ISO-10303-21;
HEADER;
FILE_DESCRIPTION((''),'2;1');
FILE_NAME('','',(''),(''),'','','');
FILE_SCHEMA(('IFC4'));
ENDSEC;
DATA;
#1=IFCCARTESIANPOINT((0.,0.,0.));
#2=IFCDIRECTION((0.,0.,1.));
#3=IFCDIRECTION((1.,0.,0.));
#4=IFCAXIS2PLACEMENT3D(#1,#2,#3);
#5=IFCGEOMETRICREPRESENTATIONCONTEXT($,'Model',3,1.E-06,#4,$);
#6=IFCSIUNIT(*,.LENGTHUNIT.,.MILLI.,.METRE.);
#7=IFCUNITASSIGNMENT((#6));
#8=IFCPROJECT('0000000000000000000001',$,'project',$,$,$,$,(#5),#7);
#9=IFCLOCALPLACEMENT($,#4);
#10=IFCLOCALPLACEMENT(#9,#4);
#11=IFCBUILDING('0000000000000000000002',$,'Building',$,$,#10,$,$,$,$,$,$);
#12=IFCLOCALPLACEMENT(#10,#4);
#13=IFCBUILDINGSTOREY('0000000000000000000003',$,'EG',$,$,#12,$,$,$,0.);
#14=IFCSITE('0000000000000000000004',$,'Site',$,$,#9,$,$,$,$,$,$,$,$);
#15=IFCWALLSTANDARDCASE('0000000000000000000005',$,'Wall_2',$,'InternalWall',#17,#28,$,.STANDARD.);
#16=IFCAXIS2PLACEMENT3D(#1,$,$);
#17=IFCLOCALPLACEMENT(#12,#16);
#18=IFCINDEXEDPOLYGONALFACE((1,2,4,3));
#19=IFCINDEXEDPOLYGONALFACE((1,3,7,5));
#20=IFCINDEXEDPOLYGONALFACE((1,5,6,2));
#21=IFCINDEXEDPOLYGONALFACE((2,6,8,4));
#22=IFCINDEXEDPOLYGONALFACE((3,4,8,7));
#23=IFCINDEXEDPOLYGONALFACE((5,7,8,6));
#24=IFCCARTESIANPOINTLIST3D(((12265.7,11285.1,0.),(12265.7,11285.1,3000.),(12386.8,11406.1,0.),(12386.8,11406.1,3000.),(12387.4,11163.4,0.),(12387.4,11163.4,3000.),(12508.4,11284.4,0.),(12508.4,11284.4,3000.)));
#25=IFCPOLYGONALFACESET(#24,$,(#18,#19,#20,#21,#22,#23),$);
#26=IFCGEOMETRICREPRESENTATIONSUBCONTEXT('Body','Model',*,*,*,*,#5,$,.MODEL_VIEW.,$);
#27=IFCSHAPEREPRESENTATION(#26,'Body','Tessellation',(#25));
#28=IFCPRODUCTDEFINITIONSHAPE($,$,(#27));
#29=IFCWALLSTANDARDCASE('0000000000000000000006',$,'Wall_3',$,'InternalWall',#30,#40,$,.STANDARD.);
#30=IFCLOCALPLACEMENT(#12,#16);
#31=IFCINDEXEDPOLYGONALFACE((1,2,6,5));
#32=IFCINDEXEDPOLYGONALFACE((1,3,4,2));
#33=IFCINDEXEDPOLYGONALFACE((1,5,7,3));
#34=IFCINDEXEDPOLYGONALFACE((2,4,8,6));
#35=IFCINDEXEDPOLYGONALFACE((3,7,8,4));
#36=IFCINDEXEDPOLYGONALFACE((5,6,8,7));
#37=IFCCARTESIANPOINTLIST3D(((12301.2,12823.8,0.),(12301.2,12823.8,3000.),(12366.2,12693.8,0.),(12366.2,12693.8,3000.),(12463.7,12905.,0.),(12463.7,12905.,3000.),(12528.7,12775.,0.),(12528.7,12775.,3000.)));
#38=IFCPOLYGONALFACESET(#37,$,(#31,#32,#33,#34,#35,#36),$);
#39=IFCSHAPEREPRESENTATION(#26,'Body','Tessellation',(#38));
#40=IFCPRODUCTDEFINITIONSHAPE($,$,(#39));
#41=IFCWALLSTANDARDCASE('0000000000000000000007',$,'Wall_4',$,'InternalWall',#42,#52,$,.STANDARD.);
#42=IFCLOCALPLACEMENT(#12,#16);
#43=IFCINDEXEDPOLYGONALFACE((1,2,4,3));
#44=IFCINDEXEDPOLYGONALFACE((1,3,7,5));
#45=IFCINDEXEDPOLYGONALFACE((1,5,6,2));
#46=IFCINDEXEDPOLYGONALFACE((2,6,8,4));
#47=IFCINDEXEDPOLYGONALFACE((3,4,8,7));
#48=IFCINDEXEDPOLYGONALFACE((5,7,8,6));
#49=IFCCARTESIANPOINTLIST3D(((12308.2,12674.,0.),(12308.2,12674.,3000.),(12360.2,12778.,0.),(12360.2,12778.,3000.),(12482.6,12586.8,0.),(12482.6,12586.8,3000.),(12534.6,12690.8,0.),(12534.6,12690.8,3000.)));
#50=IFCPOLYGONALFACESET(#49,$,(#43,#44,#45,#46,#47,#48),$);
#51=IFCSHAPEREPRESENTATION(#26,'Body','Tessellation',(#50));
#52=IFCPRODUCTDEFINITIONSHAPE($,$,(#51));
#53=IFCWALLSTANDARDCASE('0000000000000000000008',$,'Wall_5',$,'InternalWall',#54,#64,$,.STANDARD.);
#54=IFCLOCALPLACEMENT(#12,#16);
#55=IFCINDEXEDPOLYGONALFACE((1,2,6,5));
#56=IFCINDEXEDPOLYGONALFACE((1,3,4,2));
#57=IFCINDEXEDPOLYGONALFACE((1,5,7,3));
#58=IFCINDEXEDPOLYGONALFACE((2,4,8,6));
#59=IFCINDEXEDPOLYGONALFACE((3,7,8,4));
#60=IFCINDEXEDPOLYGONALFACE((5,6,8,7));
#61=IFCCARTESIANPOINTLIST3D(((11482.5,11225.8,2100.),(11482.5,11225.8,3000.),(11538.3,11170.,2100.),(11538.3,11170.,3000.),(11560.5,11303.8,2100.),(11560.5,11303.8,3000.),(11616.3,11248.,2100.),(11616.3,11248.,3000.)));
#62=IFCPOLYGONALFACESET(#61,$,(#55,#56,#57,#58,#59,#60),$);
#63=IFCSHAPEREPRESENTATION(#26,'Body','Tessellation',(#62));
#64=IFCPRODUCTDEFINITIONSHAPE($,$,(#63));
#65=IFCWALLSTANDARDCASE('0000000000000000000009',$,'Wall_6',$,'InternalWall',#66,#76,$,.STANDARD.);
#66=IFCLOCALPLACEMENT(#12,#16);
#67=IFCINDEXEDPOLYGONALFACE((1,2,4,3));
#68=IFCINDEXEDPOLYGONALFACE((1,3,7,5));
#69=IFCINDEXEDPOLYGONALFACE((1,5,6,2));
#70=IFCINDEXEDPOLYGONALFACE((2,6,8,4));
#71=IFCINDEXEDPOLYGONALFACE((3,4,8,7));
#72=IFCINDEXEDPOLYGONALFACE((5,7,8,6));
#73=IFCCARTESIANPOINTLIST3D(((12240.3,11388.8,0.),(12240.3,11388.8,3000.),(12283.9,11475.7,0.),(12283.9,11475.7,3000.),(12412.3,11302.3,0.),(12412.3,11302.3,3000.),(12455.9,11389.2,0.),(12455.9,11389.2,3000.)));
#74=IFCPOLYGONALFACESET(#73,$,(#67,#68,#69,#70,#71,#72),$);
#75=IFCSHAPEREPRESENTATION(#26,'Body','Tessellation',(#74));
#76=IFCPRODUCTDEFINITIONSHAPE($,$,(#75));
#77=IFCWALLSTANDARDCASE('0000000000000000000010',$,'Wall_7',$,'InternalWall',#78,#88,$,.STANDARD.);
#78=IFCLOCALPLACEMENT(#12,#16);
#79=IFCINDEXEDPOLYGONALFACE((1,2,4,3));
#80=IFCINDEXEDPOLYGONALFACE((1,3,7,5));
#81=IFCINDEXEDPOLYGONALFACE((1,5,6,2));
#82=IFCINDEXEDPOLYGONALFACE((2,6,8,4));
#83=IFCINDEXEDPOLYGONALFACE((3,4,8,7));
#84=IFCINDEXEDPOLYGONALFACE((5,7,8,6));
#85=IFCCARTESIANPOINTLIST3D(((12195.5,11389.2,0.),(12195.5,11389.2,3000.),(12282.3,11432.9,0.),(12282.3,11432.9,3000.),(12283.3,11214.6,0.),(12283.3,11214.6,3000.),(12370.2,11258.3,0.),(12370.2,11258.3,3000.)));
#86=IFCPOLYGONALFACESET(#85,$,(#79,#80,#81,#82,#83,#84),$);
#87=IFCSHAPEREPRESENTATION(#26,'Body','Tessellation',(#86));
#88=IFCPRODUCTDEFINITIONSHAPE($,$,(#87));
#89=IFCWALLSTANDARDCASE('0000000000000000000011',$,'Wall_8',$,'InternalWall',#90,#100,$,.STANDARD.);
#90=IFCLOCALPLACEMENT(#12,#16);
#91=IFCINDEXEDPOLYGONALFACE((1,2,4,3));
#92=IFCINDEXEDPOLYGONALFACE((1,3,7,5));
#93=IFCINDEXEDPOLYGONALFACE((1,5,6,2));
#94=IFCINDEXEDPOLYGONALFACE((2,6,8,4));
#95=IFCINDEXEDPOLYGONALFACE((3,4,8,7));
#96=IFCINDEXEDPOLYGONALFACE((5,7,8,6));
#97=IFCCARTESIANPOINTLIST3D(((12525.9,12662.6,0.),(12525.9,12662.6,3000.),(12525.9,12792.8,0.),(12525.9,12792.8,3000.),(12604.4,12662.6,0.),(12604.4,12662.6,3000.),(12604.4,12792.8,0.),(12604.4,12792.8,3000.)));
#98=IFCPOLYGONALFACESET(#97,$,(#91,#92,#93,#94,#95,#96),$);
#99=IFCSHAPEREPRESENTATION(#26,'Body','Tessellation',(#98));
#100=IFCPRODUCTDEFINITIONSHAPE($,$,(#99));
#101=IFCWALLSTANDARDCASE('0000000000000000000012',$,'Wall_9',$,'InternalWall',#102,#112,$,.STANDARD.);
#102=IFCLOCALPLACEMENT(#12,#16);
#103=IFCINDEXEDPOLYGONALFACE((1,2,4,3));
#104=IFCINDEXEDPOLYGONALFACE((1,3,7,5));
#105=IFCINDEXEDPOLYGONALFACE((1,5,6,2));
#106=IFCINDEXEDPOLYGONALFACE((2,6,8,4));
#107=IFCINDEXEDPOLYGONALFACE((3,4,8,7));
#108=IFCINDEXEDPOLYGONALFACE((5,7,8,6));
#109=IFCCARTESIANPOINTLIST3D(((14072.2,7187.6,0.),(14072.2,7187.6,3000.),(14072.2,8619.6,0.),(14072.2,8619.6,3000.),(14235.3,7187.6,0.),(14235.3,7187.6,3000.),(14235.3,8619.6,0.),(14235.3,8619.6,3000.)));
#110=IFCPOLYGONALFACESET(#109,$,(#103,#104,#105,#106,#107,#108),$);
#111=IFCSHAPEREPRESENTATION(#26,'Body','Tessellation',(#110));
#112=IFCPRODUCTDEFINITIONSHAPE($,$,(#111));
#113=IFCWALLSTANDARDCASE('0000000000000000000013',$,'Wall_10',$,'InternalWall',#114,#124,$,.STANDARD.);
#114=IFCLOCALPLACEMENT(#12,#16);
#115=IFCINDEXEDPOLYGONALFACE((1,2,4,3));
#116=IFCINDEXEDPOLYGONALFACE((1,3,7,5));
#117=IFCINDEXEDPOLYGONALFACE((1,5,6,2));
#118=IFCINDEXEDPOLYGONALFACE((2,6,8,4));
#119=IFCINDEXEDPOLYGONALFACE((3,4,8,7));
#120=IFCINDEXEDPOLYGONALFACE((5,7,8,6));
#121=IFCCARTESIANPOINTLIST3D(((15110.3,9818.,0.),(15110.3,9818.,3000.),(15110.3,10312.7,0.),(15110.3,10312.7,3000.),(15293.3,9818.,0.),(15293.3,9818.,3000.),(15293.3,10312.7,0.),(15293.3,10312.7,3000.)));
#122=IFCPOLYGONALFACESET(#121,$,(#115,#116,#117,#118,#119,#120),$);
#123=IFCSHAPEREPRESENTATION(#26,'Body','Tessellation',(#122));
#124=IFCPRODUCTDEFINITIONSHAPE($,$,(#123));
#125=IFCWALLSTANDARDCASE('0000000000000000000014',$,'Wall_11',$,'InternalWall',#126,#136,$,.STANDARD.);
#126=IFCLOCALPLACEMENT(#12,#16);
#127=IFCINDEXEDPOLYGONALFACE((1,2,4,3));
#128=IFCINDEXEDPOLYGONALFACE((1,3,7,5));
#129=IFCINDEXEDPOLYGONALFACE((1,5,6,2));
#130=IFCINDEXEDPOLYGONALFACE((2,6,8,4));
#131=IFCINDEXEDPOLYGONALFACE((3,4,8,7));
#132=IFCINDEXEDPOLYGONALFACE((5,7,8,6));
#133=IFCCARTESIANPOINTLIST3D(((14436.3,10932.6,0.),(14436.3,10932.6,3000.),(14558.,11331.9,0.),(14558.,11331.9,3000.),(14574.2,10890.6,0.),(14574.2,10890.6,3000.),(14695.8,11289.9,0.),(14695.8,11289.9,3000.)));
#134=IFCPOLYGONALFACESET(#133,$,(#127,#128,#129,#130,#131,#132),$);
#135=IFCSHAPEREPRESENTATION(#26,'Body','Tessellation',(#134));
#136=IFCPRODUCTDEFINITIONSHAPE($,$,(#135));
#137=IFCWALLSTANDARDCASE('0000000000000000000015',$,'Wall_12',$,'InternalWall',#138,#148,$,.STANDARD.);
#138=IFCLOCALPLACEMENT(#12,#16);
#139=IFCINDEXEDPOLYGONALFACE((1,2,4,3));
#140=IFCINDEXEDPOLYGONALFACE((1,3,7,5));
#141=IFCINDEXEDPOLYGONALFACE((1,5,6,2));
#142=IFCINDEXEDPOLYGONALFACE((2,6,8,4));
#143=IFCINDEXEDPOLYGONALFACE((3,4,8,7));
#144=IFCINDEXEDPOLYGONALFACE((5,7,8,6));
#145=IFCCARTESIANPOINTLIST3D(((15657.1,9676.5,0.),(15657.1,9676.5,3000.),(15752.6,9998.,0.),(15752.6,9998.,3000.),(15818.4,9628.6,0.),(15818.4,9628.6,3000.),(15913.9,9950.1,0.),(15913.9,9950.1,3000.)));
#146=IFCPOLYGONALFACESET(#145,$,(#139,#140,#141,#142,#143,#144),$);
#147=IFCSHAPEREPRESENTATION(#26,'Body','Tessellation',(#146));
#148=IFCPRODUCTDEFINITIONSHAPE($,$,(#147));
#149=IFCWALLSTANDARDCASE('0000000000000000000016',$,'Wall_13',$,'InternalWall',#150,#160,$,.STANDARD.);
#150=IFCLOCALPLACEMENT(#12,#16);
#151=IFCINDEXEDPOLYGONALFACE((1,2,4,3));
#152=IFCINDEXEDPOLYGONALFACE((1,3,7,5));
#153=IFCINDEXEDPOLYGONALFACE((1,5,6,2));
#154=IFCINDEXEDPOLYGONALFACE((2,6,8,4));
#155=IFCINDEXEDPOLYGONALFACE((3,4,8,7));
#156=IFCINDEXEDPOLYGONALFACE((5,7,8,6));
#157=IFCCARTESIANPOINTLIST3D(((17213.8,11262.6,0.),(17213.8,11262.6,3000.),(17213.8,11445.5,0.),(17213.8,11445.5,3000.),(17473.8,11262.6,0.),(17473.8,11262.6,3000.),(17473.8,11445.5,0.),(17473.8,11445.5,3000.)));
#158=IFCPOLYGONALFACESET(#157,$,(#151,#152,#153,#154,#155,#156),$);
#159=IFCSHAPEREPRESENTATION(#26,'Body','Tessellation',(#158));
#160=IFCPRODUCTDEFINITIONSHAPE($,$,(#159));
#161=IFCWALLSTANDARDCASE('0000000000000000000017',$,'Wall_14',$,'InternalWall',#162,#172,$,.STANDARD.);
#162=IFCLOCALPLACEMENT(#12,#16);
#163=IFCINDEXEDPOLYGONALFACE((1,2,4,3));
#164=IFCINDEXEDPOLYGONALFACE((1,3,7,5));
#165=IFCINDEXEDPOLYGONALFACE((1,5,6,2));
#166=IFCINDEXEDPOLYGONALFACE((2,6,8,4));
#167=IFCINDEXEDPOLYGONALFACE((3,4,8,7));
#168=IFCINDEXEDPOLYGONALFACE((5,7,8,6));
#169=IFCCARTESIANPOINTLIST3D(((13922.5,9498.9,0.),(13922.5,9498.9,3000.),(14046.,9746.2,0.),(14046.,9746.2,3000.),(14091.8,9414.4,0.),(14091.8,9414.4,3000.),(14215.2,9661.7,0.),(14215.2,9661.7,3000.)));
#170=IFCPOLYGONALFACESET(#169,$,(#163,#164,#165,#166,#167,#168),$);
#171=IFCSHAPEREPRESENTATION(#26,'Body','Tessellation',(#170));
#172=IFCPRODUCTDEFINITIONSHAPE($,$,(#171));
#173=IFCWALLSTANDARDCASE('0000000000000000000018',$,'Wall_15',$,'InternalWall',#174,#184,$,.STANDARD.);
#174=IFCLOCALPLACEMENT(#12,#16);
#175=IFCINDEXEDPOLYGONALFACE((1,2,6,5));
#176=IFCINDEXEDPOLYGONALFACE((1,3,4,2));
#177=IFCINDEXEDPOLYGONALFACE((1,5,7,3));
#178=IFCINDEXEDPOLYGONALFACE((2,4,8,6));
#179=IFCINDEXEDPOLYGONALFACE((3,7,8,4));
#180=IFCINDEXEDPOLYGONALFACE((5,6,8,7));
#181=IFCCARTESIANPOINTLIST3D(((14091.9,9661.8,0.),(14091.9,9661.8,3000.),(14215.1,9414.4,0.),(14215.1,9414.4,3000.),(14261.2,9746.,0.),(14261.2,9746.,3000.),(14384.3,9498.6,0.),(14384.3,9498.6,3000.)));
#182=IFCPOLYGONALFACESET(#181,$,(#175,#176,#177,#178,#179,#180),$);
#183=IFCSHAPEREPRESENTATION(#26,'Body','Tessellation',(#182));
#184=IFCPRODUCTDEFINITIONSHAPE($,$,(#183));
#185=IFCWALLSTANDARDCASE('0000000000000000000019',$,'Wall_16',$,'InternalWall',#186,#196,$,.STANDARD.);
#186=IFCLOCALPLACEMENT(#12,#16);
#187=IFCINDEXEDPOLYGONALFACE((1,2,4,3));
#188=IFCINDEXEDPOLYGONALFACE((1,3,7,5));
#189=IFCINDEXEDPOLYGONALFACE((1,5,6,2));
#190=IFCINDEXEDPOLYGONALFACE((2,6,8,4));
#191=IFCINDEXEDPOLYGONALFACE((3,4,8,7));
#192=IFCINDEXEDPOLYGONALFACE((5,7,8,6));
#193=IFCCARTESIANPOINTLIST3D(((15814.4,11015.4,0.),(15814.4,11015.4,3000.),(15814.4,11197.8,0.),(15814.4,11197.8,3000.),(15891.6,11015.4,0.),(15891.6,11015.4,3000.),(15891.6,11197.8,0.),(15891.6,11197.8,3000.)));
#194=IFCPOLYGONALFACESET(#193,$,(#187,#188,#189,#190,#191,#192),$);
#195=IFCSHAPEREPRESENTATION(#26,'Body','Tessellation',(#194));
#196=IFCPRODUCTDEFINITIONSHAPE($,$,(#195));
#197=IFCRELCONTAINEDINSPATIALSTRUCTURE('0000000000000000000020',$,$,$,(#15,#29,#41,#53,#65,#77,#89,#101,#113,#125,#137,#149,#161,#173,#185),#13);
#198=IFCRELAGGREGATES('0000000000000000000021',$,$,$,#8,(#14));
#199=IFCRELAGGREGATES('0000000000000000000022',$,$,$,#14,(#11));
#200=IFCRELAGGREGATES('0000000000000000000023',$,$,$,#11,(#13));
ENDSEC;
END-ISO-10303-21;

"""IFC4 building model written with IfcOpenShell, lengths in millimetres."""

from ifc_helpers import new_model, si_unit, frame, origin_with_axes, place, context, subcontext, project, spatial, rectangle, extrude, element, save


model = new_model("IFC4")

# Units and contexts
model_context = context("Model", 3, precision=1e-06, world=origin_with_axes())
body_context = subcontext(model_context, "Body", "Model", "MODEL_VIEW")
ifc_project = project(units=[si_unit("LENGTHUNIT", "METRE", prefix="MILLI")], contexts=[model_context])

# Site, building, storey
site_placement = place(None, origin_with_axes())
site = spatial("IfcSite", under=ifc_project, at=site_placement, Name="Site")
building_placement = place(site_placement, origin_with_axes())
building = spatial("IfcBuilding", under=site, at=building_placement, Name="Building")
storey_placement = place(building_placement, origin_with_axes())
storey = spatial("IfcBuildingStorey", under=building, at=storey_placement, Name="EG", Elevation=0.0)

# Walls
wall_1_placement = place(storey_placement, origin_with_axes())
element("IfcWallStandardCase", 1, at=wall_1_placement, inside=storey, Name="Wall_2", ObjectType="InternalWall", PredefinedType="STANDARD", context=body_context, shape_type="SweptSolid", body=[
    extrude(rectangle(XDim=172.1, YDim=171.2), frame((12387.1, 11284.8, 0.0), z_axis=(0.0, 0.0, 1.0), x_axis=(0.707107, -0.707107, 0.0)), (0.0, 0.0, 1.0), 3000.0),
])
wall_2_placement = place(storey_placement, origin_with_axes())
element("IfcWallStandardCase", 2, at=wall_2_placement, inside=storey, Name="Wall_3", ObjectType="InternalWall", PredefinedType="STANDARD", context=body_context, shape_type="SweptSolid", body=[
    extrude(rectangle(XDim=145.3, YDim=181.7), frame((12414.9, 12799.4, 0.0), z_axis=(0.0, 0.0, 1.0), x_axis=(-0.447214, 0.894427, 0.0)), (0.0, 0.0, 1.0), 3000.0),
])
wall_3_placement = place(storey_placement, origin_with_axes())
element("IfcWallStandardCase", 3, at=wall_3_placement, inside=storey, Name="Wall_4", ObjectType="InternalWall", PredefinedType="STANDARD", context=body_context, shape_type="SweptSolid", body=[
    extrude(rectangle(XDim=116.3, YDim=195.0), frame((12421.4, 12682.4, 0.0), z_axis=(0.0, 0.0, 1.0), x_axis=(0.447214, 0.894427, 0.0)), (0.0, 0.0, 1.0), 3000.0),
])

# Wall, opening
wall_4_placement = place(storey_placement, origin_with_axes())
wall_4 = element("IfcWallStandardCase", 4, at=wall_4_placement, inside=storey, Name="Wall_5", ObjectType="InternalWall", PredefinedType="STANDARD", context=body_context, shape_type="SweptSolid", body=[
    extrude(rectangle(XDim=110.3, YDim=79.0), frame((11549.4, 11236.9, 0.0), z_axis=(0.0, 0.0, 1.0), x_axis=(-0.707107, -0.707107, 0.0)), (0.0, 0.0, 1.0), 3000.0),
])
opening_1_placement = place(wall_4_placement, origin_with_axes())
element("IfcOpeningElement", 5, at=opening_1_placement, inside=storey, cuts=wall_4, context=body_context, shape_type="SweptSolid", body=[
    extrude(rectangle(XDim=450.0, YDim=79.0), frame((11549.4, 11236.9, 0.0), z_axis=(0.0, 0.0, 1.0), x_axis=(-0.707107, -0.707107, 0.0)), (0.0, 0.0, 1.0), 2100.0),
])

# Walls
wall_5_placement = place(storey_placement, origin_with_axes())
element("IfcWallStandardCase", 6, at=wall_5_placement, inside=storey, Name="Wall_6", ObjectType="InternalWall", PredefinedType="STANDARD", context=body_context, shape_type="SweptSolid", body=[
    extrude(rectangle(XDim=97.2, YDim=192.5), frame((12348.1, 11389.0, 0.0), z_axis=(0.0, 0.0, 1.0), x_axis=(-0.44927, -0.893396, 0.0)), (0.0, 0.0, 1.0), 3000.0),
])
wall_6_placement = place(storey_placement, origin_with_axes())
element("IfcWallStandardCase", 7, at=wall_6_placement, inside=storey, Name="Wall_7", ObjectType="InternalWall", PredefinedType="STANDARD", context=body_context, shape_type="SweptSolid", body=[
    extrude(rectangle(XDim=97.2, YDim=195.4), frame((12282.8, 11323.8, 0.0), z_axis=(0.0, 0.0, 1.0), x_axis=(-0.893396, -0.44927, 0.0)), (0.0, 0.0, 1.0), 3000.0),
])
wall_7_placement = place(storey_placement, origin_with_axes())
element("IfcWallStandardCase", 8, at=wall_7_placement, inside=storey, Name="Wall_8", ObjectType="InternalWall", PredefinedType="STANDARD", context=body_context, shape_type="SweptSolid", body=[
    extrude(rectangle(XDim=78.5, YDim=130.2), frame((12565.2, 12727.7, 0.0), z_axis=(0.0, 0.0, 1.0), x_axis=(-1.0, 0.0, 0.0)), (0.0, 0.0, 1.0), 3000.0),
])
wall_8_placement = place(storey_placement, origin_with_axes())
element("IfcWallStandardCase", 9, at=wall_8_placement, inside=storey, Name="Wall_9", ObjectType="InternalWall", PredefinedType="STANDARD", context=body_context, shape_type="SweptSolid", body=[
    extrude(rectangle(XDim=1432.0, YDim=163.2), frame((14153.8, 7903.6, 0.0), z_axis=(0.0, 0.0, 1.0), x_axis=(0.0, 1.0, 0.0)), (0.0, 0.0, 1.0), 3000.0),
])
wall_9_placement = place(storey_placement, origin_with_axes())
element("IfcWallStandardCase", 10, at=wall_9_placement, inside=storey, Name="Wall_10", ObjectType="InternalWall", PredefinedType="STANDARD", context=body_context, shape_type="SweptSolid", body=[
    extrude(rectangle(XDim=494.7, YDim=183.0), frame((15201.8, 10065.3, 0.0), z_axis=(0.0, 0.0, 1.0), x_axis=(0.0, -1.0, 0.0)), (0.0, 0.0, 1.0), 3000.0),
])
wall_10_placement = place(storey_placement, origin_with_axes())
element("IfcWallStandardCase", 11, at=wall_10_placement, inside=storey, Name="Wall_11", ObjectType="InternalWall", PredefinedType="STANDARD", context=body_context, shape_type="SweptSolid", body=[
    extrude(rectangle(XDim=417.5, YDim=144.1), frame((14566.1, 11111.3, 0.0), z_axis=(0.0, 0.0, 1.0), x_axis=(-0.291448, -0.956587, 0.0)), (0.0, 0.0, 1.0), 3000.0),
])
wall_11_placement = place(storey_placement, origin_with_axes())
element("IfcWallStandardCase", 12, at=wall_11_placement, inside=storey, Name="Wall_12", ObjectType="InternalWall", PredefinedType="STANDARD", context=body_context, shape_type="SweptSolid", body=[
    extrude(rectangle(XDim=335.4, YDim=168.2), frame((15785.5, 9813.3, 0.0), z_axis=(0.0, 0.0, 1.0), x_axis=(0.284748, 0.958602, 0.0)), (0.0, 0.0, 1.0), 3000.0),
])
wall_12_placement = place(storey_placement, origin_with_axes())
element("IfcWallStandardCase", 13, at=wall_12_placement, inside=storey, Name="Wall_13", ObjectType="InternalWall", PredefinedType="STANDARD", context=body_context, shape_type="SweptSolid", body=[
    extrude(rectangle(XDim=260.0, YDim=182.9), frame((17343.8, 11354.1, 0.0), z_axis=(0.0, 0.0, 1.0), x_axis=(-1.0, 0.0, 0.0)), (0.0, 0.0, 1.0), 3000.0),
])
wall_13_placement = place(storey_placement, origin_with_axes())
element("IfcWallStandardCase", 14, at=wall_13_placement, inside=storey, Name="Wall_14", ObjectType="InternalWall", PredefinedType="STANDARD", context=body_context, shape_type="SweptSolid", body=[
    extrude(rectangle(XDim=189.2, YDim=276.4), frame((14068.9, 9580.3, 0.0), z_axis=(0.0, 0.0, 1.0), x_axis=(0.894691, -0.446685, 0.0)), (0.0, 0.0, 1.0), 3000.0),
])
wall_14_placement = place(storey_placement, origin_with_axes())
element("IfcWallStandardCase", 15, at=wall_14_placement, inside=storey, Name="Wall_15", ObjectType="InternalWall", PredefinedType="STANDARD", context=body_context, shape_type="SweptSolid", body=[
    extrude(rectangle(XDim=189.1, YDim=276.3), frame((14238.1, 9580.2, 0.0), z_axis=(0.0, 0.0, 1.0), x_axis=(0.895219, 0.445626, 0.0)), (0.0, 0.0, 1.0), 3000.0),
])
wall_15_placement = place(storey_placement, origin_with_axes())
element("IfcWallStandardCase", 16, at=wall_15_placement, inside=storey, Name="Wall_16", ObjectType="InternalWall", PredefinedType="STANDARD", context=body_context, shape_type="SweptSolid", body=[
    extrude(rectangle(XDim=182.4, YDim=77.2), frame((15853.0, 11106.6, 0.0), z_axis=(0.0, 0.0, 1.0), x_axis=(0.0, -1.0, 0.0)), (0.0, 0.0, 1.0), 3000.0),
])

save(model, "model.ifc")
